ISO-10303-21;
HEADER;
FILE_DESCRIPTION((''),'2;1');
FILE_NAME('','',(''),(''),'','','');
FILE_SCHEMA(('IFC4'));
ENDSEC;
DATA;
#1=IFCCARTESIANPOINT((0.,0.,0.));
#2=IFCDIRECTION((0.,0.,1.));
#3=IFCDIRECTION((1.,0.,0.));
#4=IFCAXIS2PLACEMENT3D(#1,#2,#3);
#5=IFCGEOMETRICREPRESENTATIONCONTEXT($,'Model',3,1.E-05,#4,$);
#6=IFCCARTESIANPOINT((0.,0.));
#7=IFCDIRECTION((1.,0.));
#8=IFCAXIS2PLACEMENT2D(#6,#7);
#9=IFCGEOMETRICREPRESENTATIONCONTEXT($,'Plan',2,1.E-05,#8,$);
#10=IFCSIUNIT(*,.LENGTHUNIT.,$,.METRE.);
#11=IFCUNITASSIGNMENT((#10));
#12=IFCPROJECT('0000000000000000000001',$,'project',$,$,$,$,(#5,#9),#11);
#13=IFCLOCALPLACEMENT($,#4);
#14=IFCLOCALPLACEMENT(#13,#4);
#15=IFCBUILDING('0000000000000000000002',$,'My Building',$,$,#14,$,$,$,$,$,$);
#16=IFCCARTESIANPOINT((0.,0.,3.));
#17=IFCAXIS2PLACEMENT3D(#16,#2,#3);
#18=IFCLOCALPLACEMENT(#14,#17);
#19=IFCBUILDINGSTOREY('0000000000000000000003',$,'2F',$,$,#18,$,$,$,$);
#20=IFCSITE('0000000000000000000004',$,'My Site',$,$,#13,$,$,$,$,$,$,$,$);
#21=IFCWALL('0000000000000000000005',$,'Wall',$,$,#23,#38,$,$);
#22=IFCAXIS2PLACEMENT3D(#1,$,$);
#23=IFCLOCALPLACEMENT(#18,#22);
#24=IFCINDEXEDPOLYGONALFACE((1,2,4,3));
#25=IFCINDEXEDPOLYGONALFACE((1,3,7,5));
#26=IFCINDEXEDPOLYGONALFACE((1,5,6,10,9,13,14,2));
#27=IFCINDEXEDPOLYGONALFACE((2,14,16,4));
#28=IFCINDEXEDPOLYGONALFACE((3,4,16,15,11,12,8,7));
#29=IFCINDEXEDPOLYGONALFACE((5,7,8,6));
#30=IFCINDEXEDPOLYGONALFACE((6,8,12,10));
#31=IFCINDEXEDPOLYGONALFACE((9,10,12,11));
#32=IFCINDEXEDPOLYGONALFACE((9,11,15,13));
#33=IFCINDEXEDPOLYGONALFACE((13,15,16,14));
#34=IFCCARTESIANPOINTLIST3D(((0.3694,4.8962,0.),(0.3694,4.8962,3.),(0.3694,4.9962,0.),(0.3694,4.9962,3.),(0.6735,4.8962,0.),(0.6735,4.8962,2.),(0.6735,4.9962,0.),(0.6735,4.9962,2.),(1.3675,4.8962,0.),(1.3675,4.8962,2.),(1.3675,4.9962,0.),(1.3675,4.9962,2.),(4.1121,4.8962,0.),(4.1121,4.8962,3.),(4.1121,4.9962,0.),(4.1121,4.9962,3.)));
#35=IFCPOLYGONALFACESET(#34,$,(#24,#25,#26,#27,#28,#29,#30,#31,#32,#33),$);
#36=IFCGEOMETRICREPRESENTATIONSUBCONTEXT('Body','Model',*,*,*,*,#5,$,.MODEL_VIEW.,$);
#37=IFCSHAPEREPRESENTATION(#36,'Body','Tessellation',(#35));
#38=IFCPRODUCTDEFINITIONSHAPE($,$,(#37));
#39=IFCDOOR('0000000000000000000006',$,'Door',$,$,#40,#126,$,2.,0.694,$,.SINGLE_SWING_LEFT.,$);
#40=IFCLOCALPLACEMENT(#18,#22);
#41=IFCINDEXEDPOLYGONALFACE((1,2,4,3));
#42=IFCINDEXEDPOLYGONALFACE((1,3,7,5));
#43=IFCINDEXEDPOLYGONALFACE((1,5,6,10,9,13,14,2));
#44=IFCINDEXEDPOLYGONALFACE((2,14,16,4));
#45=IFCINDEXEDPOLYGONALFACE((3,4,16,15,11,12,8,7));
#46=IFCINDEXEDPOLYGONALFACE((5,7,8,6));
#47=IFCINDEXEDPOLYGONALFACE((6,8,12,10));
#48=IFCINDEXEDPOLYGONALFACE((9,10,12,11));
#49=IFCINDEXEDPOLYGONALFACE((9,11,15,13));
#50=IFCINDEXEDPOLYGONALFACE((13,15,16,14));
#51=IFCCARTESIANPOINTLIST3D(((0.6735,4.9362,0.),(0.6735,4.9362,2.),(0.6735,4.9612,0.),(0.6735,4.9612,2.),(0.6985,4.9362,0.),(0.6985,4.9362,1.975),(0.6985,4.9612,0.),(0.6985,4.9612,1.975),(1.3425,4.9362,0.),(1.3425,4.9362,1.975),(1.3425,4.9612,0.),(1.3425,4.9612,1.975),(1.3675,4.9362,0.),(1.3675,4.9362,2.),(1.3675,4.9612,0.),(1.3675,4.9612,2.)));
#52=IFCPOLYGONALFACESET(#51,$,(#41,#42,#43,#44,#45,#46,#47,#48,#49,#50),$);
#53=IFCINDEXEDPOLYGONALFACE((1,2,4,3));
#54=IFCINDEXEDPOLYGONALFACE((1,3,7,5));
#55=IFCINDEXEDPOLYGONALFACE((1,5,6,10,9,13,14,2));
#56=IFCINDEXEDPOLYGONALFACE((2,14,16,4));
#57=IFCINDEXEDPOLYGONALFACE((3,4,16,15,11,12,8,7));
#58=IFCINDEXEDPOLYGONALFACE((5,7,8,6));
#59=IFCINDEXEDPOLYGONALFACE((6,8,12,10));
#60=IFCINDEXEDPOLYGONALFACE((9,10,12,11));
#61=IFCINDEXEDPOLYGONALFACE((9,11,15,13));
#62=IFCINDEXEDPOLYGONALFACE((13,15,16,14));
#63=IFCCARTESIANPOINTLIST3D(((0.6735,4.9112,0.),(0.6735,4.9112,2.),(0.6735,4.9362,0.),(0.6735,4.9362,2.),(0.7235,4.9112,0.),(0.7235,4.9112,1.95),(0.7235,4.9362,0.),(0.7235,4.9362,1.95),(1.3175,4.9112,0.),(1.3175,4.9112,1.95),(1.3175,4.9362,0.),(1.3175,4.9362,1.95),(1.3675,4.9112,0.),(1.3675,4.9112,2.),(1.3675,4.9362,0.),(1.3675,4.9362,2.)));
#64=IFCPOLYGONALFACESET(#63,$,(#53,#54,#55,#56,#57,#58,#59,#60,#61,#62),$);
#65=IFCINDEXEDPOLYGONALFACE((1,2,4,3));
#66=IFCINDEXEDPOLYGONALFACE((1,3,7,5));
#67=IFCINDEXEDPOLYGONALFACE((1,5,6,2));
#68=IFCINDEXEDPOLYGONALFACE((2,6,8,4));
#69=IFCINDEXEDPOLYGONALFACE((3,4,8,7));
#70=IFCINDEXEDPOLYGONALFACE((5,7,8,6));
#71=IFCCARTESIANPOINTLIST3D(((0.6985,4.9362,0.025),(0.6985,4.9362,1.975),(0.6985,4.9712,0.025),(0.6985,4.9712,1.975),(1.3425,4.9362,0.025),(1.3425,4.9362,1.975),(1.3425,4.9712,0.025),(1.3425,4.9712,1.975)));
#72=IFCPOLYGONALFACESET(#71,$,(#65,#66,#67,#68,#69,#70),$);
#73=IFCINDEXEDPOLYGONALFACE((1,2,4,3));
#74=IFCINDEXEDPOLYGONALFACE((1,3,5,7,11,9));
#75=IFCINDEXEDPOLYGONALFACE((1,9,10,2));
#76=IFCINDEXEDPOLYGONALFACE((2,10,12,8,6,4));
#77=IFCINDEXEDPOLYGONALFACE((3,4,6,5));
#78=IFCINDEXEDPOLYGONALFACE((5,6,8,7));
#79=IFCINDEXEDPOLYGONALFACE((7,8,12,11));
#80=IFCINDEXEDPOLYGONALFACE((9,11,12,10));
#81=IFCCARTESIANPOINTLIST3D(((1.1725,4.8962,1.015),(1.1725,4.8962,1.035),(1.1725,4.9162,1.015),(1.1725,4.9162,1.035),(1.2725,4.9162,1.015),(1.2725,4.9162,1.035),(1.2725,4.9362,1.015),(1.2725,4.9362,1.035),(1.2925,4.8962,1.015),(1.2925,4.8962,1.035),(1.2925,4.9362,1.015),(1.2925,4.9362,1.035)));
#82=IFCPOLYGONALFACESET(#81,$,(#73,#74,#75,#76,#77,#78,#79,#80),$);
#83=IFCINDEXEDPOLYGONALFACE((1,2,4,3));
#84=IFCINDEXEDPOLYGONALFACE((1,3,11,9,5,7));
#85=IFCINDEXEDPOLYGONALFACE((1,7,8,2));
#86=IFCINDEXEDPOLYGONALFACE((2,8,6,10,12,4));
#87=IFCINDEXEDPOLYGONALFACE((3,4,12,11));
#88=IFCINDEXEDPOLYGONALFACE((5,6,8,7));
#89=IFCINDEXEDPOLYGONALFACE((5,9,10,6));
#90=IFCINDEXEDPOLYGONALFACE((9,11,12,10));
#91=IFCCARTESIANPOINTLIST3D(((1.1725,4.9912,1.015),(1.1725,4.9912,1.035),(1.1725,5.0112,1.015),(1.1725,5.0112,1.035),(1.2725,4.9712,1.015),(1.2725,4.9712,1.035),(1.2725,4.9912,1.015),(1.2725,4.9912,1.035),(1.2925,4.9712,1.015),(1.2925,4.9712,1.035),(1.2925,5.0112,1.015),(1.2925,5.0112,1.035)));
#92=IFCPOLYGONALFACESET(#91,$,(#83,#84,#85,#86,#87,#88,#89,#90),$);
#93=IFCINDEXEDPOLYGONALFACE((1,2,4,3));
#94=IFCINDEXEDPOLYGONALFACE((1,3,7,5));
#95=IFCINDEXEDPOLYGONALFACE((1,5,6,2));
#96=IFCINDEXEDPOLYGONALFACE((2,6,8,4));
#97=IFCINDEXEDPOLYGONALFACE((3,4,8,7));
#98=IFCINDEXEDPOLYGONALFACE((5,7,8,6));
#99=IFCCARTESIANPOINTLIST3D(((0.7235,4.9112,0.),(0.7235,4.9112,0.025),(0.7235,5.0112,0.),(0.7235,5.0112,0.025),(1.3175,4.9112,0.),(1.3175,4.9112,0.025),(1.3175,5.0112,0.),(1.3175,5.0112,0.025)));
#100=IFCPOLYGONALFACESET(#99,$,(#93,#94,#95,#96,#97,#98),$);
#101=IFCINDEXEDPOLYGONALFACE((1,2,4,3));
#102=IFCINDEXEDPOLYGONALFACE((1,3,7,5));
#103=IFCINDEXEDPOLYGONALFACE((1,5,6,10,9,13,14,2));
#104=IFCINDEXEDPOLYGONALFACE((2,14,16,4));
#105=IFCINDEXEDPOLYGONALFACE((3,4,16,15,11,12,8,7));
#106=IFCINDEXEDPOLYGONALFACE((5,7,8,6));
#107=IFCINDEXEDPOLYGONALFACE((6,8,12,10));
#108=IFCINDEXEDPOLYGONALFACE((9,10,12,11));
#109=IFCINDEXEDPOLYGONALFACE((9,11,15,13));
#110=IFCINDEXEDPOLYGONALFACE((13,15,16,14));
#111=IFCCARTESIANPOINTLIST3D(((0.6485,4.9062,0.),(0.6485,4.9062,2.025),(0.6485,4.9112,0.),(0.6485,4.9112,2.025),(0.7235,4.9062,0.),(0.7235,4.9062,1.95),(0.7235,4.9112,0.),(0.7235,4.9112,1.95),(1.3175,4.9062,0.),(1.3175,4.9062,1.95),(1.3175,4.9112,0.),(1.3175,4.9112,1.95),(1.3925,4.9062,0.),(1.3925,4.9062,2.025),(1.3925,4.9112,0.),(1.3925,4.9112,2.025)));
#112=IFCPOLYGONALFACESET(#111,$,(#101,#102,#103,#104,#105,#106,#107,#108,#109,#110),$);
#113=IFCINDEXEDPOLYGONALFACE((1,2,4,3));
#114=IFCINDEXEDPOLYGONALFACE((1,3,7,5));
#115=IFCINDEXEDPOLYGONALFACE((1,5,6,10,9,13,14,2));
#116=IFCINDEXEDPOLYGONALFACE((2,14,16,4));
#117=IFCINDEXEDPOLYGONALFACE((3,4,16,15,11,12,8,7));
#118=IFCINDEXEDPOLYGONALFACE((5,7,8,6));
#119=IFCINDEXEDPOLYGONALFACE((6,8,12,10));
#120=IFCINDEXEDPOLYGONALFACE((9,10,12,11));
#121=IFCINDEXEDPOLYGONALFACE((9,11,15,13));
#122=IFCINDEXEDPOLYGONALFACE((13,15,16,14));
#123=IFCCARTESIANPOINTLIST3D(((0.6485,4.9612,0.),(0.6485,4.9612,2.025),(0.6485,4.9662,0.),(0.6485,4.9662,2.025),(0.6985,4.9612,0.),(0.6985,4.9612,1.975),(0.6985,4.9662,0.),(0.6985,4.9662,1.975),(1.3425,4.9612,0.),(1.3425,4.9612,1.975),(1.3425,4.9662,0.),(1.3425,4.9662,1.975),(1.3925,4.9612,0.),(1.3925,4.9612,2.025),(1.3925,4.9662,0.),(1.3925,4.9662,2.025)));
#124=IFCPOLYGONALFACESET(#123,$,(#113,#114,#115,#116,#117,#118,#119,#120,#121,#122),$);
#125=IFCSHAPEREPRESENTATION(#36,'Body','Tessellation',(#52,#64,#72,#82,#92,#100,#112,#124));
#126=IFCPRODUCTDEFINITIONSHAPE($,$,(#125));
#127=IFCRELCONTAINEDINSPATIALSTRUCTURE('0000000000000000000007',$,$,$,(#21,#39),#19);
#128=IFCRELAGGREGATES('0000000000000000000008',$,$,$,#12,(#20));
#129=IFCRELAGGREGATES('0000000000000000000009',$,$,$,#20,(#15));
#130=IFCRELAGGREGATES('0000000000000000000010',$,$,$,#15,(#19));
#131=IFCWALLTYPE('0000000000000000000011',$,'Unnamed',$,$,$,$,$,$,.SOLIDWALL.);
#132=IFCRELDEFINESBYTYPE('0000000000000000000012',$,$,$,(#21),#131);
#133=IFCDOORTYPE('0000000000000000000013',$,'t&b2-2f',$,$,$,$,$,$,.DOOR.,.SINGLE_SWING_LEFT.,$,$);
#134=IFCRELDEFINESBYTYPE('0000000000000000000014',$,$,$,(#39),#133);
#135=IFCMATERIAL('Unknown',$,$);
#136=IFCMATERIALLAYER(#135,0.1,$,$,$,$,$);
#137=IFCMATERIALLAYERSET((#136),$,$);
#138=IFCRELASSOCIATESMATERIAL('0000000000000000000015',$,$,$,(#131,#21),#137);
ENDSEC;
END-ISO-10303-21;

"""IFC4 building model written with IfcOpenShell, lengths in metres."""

from ifc_helpers import new_model, entity, si_unit, frame, origin_with_axes, origin_2d_with_axis, place, context, subcontext, project, spatial, line, indexed_curve, outline, extrude, shape, source, transform, mapped, material, layer, layer_set, layer_usage, type_object, type_shapes, element, fill, save


model = new_model("IFC4")

# Units and contexts
model_context = context("Model", 3, precision=1e-05, world=origin_with_axes())
plan_context = context("Plan", 2, precision=1e-05, world=origin_2d_with_axis())
body_context_1 = subcontext(model_context, "Body", "Model", "MODEL_VIEW")
body_context_2 = subcontext(plan_context, "Body", "Plan", "PLAN_VIEW")
ifc_project = project(units=[si_unit("LENGTHUNIT", "METRE")], contexts=[model_context, plan_context])

# Site, building, storey
site_placement = place(None, origin_with_axes())
site = spatial("IfcSite", under=ifc_project, at=site_placement, Name="My Site")
building_placement = place(site_placement, origin_with_axes())
building = spatial("IfcBuilding", under=site, at=building_placement, Name="My Building")
storey_placement = place(building_placement, frame((0.0, 0.0, 3.0), z_axis=(0.0, 0.0, 1.0), x_axis=(1.0, 0.0, 0.0)))
storey = spatial("IfcBuildingStorey", under=building, at=storey_placement, Name="2F")

# Shared definitions
ifc_material = material(Name="Unknown")

# Shared definitions
ifc_layer_1 = layer(ifc_material, 0.1)
ifc_layer_set_1 = layer_set([ifc_layer_1])
wall_type = type_object("IfcWallType", Name="Unnamed", PredefinedType="SOLIDWALL", material=ifc_layer_set_1)

# Wall, opening, door
ifc_layer_usage_1 = layer_usage(ifc_layer_set_1, "AXIS2", "POSITIVE", 0.0)
wall_1_placement = place(storey_placement, frame((0.3694, 4.8962, 0.0), z_axis=(0.0, 0.0, 1.0), x_axis=(1.0, 0.0, 0.0)))
wall_1 = element("IfcWall", 1, at=wall_1_placement, inside=storey, type_object=wall_type, material=ifc_layer_usage_1, Name="Wall", context=body_context_1, shape_type="SweptSolid", body=[
    extrude(outline(indexed_curve([(0.0, 0.0), (0.0, 0.1), (3.7427, 0.1), (3.7427, 0.0)], segments=[line(1, 2, 3, 4, 1)])), origin_with_axes(), (0.0, 0.0, 1.0), 3.0),
])
shared_shape_1 = source(origin_with_axes(), body_context_1, "Body", "SweptSolid", [
    extrude(outline(indexed_curve([(0.0, 0.0), (0.694, 0.0), (0.694, 2.0), (0.0, 2.0)], segments=[line(1, 2, 3, 4, 1)])), frame((0.0, -0.6, 0.0), z_axis=(0.0, -1.0, 0.0), x_axis=(1.0, 0.0, 0.0)), (0.0, 0.0, -1.0), 1.2),
])
opening_1_placement = place(wall_1_placement, frame((0.3041, 0.015, 0.0), z_axis=(0.0, 0.0, 1.0), x_axis=(1.0, 0.0, 0.0)))
opening_1 = element("IfcOpeningElement", 2, at=opening_1_placement, cuts=wall_1, PredefinedType="OPENING", context=body_context_1, shape_type="MappedRepresentation", body=[
    mapped(shared_shape_1, transform((0.0, 0.0, 0.0), x_axis=(1.0, 0.0, 0.0), y_axis=(0.0, 1.0, 0.0), z_axis=(0.0, 0.0, 1.0), scale=1.0)),
])
door_type_1 = type_object("IfcDoorType", Name="t&b2-2f", OperationType="SINGLE_SWING_LEFT", PredefinedType="DOOR")
shared_shape_2 = source(origin_with_axes(), body_context_1, "Body", "SweptSolid", [
    extrude(outline(indexed_curve([(0.0, 0.0), (0.0, 2.0), (0.694, 2.0), (0.694, 0.0), (0.669, 0.0), (0.669, 1.975), (0.025, 1.975), (0.025, 0.0)], segments=[line(1, 2, 3, 4, 5, 6, 7, 8, 1)])), frame((0.0, 0.025, 0.0), z_axis=(0.0, -1.0, 0.0), x_axis=(1.0, 0.0, 0.0)), (0.0, 0.0, -1.0), 0.025),
    extrude(outline(indexed_curve([(0.0, 0.0), (0.0, 2.0), (0.694, 2.0), (0.694, 0.0), (0.644, 0.0), (0.644, 1.95), (0.05, 1.95), (0.05, 0.0)], segments=[line(1, 2, 3, 4, 5, 6, 7, 8, 1)])), frame((0.0, 0.0, 0.0), z_axis=(0.0, -1.0, 0.0), x_axis=(1.0, 0.0, 0.0)), (0.0, 0.0, -1.0), 0.025),
    extrude(outline(indexed_curve([(0.0, 0.0), (0.644, 0.0), (0.644, 0.035), (0.0, 0.035)], segments=[line(1, 2, 3, 4, 1)])), frame((0.025, 0.025, 0.025), z_axis=(0.0, 0.0, 1.0), x_axis=(1.0, 0.0, 0.0)), (0.0, 0.0, 1.0), 1.95),
    extrude(outline(indexed_curve([(0.0, 0.0), (0.0, -0.04), (-0.12, -0.04), (-0.12, -0.02), (-0.02, -0.02), (-0.02, 0.0)], segments=[line(1, 2, 3, 4, 5, 6, 1)])), frame((0.619, 0.025, 1.015), z_axis=(0.0, 0.0, 1.0), x_axis=(1.0, 0.0, 0.0)), (0.0, 0.0, 1.0), 0.02),
    extrude(outline(indexed_curve([(0.0, 0.0), (0.0, 0.04), (-0.12, 0.04), (-0.12, 0.02), (-0.02, 0.02), (-0.02, 0.0)], segments=[line(1, 2, 3, 4, 5, 6, 1)])), frame((0.619, 0.06, 1.015), z_axis=(0.0, 0.0, 1.0), x_axis=(1.0, 0.0, 0.0)), (0.0, 0.0, 1.0), 0.02),
    extrude(outline(indexed_curve([(0.0, 0.0), (0.594, 0.0), (0.594, 0.1), (0.0, 0.1)], segments=[line(1, 2, 3, 4, 1)])), frame((0.05, 0.0, 0.0), z_axis=(0.0, 0.0, 1.0), x_axis=(1.0, 0.0, 0.0)), (0.0, 0.0, 1.0), 0.025),
    extrude(outline(indexed_curve([(0.0, 0.0), (0.0, 2.025), (0.744, 2.025), (0.744, 0.0), (0.669, 0.0), (0.669, 1.95), (0.075, 1.95), (0.075, 0.0)], segments=[line(1, 2, 3, 4, 5, 6, 7, 8, 1)])), frame((-0.025, -0.005, 0.0), z_axis=(0.0, -1.0, 0.0), x_axis=(1.0, 0.0, 0.0)), (0.0, 0.0, -1.0), 0.005),
    extrude(outline(indexed_curve([(0.0, 0.0), (0.0, 2.025), (0.744, 2.025), (0.744, 0.0), (0.694, 0.0), (0.694, 1.975), (0.05, 1.975), (0.05, 0.0)], segments=[line(1, 2, 3, 4, 5, 6, 7, 8, 1)])), frame((-0.025, 0.05, 0.0), z_axis=(0.0, -1.0, 0.0), x_axis=(1.0, 0.0, 0.0)), (0.0, 0.0, -1.0), 0.005),
])
shared_shape_3 = source(origin_with_axes(), body_context_2, "Body", "Curve2D", [
    entity("IfcIndexedPolyCurve", entity("IfcCartesianPointList2D", [[0.0, 0.0], [0.0, 0.05], [0.025, 0.05], [0.025, 0.025], [0.05, 0.025], [0.05, 0.0]]), [entity("IfcLineIndex", [1, 2, 3, 4, 5, 6, 1])]),
    entity("IfcIndexedPolyCurve", entity("IfcCartesianPointList2D", [[0.694, 0.0], [0.694, 0.05], [0.669, 0.05], [0.669, 0.025], [0.644, 0.025], [0.644, 0.0]]), [entity("IfcLineIndex", [1, 2, 3, 4, 5, 6, 1])]),
    entity("IfcTrimmedCurve", entity("IfcEllipse", entity("IfcAxis2Placement2D", entity("IfcCartesianPoint", [0.06, 0.05]), entity("IfcDirection", [1.0, 0.0])), 0.609, 0.644), [entity("IfcCartesianPoint", [0.669, 0.05])], [entity("IfcCartesianPoint", [0.06, 0.694])], True, "CARTESIAN"),
    entity("IfcIndexedPolyCurve", entity("IfcCartesianPointList2D", [[0.025, 0.05], [0.06, 0.05], [0.06, 0.694], [0.025, 0.694]]), [entity("IfcLineIndex", [1, 2, 3, 4, 1])]),
])
type_shapes(door_type_1, [shared_shape_2, shared_shape_3])
door_1_placement = place(opening_1_placement, frame((0.0, 0.0, 0.0), z_axis=(0.0, 0.0, 1.0), x_axis=(1.0, 0.0, 0.0)))
door_1 = element("IfcDoor", 3, at=door_1_placement, inside=storey, type_object=door_type_1, Name="Door", OperationType="SINGLE_SWING_LEFT", OverallHeight=2.0, OverallWidth=0.694, shapes=[
    shape(body_context_1, "Body", "MappedRepresentation", [mapped(shared_shape_2, transform((0.0, 0.0, 0.0), x_axis=(1.0, 0.0, 0.0), y_axis=(0.0, 1.0, 0.0), z_axis=(0.0, 0.0, 1.0), scale=1.0))]),
    shape(body_context_2, "Body", "MappedRepresentation", [mapped(shared_shape_3, transform((0.0, 0.0, 0.0), x_axis=(1.0, 0.0, 0.0), y_axis=(0.0, 1.0, 0.0), z_axis=(0.0, 0.0, 1.0), scale=1.0))]),
])
fill(opening_1, door_1)

save(model, "model.ifc")
